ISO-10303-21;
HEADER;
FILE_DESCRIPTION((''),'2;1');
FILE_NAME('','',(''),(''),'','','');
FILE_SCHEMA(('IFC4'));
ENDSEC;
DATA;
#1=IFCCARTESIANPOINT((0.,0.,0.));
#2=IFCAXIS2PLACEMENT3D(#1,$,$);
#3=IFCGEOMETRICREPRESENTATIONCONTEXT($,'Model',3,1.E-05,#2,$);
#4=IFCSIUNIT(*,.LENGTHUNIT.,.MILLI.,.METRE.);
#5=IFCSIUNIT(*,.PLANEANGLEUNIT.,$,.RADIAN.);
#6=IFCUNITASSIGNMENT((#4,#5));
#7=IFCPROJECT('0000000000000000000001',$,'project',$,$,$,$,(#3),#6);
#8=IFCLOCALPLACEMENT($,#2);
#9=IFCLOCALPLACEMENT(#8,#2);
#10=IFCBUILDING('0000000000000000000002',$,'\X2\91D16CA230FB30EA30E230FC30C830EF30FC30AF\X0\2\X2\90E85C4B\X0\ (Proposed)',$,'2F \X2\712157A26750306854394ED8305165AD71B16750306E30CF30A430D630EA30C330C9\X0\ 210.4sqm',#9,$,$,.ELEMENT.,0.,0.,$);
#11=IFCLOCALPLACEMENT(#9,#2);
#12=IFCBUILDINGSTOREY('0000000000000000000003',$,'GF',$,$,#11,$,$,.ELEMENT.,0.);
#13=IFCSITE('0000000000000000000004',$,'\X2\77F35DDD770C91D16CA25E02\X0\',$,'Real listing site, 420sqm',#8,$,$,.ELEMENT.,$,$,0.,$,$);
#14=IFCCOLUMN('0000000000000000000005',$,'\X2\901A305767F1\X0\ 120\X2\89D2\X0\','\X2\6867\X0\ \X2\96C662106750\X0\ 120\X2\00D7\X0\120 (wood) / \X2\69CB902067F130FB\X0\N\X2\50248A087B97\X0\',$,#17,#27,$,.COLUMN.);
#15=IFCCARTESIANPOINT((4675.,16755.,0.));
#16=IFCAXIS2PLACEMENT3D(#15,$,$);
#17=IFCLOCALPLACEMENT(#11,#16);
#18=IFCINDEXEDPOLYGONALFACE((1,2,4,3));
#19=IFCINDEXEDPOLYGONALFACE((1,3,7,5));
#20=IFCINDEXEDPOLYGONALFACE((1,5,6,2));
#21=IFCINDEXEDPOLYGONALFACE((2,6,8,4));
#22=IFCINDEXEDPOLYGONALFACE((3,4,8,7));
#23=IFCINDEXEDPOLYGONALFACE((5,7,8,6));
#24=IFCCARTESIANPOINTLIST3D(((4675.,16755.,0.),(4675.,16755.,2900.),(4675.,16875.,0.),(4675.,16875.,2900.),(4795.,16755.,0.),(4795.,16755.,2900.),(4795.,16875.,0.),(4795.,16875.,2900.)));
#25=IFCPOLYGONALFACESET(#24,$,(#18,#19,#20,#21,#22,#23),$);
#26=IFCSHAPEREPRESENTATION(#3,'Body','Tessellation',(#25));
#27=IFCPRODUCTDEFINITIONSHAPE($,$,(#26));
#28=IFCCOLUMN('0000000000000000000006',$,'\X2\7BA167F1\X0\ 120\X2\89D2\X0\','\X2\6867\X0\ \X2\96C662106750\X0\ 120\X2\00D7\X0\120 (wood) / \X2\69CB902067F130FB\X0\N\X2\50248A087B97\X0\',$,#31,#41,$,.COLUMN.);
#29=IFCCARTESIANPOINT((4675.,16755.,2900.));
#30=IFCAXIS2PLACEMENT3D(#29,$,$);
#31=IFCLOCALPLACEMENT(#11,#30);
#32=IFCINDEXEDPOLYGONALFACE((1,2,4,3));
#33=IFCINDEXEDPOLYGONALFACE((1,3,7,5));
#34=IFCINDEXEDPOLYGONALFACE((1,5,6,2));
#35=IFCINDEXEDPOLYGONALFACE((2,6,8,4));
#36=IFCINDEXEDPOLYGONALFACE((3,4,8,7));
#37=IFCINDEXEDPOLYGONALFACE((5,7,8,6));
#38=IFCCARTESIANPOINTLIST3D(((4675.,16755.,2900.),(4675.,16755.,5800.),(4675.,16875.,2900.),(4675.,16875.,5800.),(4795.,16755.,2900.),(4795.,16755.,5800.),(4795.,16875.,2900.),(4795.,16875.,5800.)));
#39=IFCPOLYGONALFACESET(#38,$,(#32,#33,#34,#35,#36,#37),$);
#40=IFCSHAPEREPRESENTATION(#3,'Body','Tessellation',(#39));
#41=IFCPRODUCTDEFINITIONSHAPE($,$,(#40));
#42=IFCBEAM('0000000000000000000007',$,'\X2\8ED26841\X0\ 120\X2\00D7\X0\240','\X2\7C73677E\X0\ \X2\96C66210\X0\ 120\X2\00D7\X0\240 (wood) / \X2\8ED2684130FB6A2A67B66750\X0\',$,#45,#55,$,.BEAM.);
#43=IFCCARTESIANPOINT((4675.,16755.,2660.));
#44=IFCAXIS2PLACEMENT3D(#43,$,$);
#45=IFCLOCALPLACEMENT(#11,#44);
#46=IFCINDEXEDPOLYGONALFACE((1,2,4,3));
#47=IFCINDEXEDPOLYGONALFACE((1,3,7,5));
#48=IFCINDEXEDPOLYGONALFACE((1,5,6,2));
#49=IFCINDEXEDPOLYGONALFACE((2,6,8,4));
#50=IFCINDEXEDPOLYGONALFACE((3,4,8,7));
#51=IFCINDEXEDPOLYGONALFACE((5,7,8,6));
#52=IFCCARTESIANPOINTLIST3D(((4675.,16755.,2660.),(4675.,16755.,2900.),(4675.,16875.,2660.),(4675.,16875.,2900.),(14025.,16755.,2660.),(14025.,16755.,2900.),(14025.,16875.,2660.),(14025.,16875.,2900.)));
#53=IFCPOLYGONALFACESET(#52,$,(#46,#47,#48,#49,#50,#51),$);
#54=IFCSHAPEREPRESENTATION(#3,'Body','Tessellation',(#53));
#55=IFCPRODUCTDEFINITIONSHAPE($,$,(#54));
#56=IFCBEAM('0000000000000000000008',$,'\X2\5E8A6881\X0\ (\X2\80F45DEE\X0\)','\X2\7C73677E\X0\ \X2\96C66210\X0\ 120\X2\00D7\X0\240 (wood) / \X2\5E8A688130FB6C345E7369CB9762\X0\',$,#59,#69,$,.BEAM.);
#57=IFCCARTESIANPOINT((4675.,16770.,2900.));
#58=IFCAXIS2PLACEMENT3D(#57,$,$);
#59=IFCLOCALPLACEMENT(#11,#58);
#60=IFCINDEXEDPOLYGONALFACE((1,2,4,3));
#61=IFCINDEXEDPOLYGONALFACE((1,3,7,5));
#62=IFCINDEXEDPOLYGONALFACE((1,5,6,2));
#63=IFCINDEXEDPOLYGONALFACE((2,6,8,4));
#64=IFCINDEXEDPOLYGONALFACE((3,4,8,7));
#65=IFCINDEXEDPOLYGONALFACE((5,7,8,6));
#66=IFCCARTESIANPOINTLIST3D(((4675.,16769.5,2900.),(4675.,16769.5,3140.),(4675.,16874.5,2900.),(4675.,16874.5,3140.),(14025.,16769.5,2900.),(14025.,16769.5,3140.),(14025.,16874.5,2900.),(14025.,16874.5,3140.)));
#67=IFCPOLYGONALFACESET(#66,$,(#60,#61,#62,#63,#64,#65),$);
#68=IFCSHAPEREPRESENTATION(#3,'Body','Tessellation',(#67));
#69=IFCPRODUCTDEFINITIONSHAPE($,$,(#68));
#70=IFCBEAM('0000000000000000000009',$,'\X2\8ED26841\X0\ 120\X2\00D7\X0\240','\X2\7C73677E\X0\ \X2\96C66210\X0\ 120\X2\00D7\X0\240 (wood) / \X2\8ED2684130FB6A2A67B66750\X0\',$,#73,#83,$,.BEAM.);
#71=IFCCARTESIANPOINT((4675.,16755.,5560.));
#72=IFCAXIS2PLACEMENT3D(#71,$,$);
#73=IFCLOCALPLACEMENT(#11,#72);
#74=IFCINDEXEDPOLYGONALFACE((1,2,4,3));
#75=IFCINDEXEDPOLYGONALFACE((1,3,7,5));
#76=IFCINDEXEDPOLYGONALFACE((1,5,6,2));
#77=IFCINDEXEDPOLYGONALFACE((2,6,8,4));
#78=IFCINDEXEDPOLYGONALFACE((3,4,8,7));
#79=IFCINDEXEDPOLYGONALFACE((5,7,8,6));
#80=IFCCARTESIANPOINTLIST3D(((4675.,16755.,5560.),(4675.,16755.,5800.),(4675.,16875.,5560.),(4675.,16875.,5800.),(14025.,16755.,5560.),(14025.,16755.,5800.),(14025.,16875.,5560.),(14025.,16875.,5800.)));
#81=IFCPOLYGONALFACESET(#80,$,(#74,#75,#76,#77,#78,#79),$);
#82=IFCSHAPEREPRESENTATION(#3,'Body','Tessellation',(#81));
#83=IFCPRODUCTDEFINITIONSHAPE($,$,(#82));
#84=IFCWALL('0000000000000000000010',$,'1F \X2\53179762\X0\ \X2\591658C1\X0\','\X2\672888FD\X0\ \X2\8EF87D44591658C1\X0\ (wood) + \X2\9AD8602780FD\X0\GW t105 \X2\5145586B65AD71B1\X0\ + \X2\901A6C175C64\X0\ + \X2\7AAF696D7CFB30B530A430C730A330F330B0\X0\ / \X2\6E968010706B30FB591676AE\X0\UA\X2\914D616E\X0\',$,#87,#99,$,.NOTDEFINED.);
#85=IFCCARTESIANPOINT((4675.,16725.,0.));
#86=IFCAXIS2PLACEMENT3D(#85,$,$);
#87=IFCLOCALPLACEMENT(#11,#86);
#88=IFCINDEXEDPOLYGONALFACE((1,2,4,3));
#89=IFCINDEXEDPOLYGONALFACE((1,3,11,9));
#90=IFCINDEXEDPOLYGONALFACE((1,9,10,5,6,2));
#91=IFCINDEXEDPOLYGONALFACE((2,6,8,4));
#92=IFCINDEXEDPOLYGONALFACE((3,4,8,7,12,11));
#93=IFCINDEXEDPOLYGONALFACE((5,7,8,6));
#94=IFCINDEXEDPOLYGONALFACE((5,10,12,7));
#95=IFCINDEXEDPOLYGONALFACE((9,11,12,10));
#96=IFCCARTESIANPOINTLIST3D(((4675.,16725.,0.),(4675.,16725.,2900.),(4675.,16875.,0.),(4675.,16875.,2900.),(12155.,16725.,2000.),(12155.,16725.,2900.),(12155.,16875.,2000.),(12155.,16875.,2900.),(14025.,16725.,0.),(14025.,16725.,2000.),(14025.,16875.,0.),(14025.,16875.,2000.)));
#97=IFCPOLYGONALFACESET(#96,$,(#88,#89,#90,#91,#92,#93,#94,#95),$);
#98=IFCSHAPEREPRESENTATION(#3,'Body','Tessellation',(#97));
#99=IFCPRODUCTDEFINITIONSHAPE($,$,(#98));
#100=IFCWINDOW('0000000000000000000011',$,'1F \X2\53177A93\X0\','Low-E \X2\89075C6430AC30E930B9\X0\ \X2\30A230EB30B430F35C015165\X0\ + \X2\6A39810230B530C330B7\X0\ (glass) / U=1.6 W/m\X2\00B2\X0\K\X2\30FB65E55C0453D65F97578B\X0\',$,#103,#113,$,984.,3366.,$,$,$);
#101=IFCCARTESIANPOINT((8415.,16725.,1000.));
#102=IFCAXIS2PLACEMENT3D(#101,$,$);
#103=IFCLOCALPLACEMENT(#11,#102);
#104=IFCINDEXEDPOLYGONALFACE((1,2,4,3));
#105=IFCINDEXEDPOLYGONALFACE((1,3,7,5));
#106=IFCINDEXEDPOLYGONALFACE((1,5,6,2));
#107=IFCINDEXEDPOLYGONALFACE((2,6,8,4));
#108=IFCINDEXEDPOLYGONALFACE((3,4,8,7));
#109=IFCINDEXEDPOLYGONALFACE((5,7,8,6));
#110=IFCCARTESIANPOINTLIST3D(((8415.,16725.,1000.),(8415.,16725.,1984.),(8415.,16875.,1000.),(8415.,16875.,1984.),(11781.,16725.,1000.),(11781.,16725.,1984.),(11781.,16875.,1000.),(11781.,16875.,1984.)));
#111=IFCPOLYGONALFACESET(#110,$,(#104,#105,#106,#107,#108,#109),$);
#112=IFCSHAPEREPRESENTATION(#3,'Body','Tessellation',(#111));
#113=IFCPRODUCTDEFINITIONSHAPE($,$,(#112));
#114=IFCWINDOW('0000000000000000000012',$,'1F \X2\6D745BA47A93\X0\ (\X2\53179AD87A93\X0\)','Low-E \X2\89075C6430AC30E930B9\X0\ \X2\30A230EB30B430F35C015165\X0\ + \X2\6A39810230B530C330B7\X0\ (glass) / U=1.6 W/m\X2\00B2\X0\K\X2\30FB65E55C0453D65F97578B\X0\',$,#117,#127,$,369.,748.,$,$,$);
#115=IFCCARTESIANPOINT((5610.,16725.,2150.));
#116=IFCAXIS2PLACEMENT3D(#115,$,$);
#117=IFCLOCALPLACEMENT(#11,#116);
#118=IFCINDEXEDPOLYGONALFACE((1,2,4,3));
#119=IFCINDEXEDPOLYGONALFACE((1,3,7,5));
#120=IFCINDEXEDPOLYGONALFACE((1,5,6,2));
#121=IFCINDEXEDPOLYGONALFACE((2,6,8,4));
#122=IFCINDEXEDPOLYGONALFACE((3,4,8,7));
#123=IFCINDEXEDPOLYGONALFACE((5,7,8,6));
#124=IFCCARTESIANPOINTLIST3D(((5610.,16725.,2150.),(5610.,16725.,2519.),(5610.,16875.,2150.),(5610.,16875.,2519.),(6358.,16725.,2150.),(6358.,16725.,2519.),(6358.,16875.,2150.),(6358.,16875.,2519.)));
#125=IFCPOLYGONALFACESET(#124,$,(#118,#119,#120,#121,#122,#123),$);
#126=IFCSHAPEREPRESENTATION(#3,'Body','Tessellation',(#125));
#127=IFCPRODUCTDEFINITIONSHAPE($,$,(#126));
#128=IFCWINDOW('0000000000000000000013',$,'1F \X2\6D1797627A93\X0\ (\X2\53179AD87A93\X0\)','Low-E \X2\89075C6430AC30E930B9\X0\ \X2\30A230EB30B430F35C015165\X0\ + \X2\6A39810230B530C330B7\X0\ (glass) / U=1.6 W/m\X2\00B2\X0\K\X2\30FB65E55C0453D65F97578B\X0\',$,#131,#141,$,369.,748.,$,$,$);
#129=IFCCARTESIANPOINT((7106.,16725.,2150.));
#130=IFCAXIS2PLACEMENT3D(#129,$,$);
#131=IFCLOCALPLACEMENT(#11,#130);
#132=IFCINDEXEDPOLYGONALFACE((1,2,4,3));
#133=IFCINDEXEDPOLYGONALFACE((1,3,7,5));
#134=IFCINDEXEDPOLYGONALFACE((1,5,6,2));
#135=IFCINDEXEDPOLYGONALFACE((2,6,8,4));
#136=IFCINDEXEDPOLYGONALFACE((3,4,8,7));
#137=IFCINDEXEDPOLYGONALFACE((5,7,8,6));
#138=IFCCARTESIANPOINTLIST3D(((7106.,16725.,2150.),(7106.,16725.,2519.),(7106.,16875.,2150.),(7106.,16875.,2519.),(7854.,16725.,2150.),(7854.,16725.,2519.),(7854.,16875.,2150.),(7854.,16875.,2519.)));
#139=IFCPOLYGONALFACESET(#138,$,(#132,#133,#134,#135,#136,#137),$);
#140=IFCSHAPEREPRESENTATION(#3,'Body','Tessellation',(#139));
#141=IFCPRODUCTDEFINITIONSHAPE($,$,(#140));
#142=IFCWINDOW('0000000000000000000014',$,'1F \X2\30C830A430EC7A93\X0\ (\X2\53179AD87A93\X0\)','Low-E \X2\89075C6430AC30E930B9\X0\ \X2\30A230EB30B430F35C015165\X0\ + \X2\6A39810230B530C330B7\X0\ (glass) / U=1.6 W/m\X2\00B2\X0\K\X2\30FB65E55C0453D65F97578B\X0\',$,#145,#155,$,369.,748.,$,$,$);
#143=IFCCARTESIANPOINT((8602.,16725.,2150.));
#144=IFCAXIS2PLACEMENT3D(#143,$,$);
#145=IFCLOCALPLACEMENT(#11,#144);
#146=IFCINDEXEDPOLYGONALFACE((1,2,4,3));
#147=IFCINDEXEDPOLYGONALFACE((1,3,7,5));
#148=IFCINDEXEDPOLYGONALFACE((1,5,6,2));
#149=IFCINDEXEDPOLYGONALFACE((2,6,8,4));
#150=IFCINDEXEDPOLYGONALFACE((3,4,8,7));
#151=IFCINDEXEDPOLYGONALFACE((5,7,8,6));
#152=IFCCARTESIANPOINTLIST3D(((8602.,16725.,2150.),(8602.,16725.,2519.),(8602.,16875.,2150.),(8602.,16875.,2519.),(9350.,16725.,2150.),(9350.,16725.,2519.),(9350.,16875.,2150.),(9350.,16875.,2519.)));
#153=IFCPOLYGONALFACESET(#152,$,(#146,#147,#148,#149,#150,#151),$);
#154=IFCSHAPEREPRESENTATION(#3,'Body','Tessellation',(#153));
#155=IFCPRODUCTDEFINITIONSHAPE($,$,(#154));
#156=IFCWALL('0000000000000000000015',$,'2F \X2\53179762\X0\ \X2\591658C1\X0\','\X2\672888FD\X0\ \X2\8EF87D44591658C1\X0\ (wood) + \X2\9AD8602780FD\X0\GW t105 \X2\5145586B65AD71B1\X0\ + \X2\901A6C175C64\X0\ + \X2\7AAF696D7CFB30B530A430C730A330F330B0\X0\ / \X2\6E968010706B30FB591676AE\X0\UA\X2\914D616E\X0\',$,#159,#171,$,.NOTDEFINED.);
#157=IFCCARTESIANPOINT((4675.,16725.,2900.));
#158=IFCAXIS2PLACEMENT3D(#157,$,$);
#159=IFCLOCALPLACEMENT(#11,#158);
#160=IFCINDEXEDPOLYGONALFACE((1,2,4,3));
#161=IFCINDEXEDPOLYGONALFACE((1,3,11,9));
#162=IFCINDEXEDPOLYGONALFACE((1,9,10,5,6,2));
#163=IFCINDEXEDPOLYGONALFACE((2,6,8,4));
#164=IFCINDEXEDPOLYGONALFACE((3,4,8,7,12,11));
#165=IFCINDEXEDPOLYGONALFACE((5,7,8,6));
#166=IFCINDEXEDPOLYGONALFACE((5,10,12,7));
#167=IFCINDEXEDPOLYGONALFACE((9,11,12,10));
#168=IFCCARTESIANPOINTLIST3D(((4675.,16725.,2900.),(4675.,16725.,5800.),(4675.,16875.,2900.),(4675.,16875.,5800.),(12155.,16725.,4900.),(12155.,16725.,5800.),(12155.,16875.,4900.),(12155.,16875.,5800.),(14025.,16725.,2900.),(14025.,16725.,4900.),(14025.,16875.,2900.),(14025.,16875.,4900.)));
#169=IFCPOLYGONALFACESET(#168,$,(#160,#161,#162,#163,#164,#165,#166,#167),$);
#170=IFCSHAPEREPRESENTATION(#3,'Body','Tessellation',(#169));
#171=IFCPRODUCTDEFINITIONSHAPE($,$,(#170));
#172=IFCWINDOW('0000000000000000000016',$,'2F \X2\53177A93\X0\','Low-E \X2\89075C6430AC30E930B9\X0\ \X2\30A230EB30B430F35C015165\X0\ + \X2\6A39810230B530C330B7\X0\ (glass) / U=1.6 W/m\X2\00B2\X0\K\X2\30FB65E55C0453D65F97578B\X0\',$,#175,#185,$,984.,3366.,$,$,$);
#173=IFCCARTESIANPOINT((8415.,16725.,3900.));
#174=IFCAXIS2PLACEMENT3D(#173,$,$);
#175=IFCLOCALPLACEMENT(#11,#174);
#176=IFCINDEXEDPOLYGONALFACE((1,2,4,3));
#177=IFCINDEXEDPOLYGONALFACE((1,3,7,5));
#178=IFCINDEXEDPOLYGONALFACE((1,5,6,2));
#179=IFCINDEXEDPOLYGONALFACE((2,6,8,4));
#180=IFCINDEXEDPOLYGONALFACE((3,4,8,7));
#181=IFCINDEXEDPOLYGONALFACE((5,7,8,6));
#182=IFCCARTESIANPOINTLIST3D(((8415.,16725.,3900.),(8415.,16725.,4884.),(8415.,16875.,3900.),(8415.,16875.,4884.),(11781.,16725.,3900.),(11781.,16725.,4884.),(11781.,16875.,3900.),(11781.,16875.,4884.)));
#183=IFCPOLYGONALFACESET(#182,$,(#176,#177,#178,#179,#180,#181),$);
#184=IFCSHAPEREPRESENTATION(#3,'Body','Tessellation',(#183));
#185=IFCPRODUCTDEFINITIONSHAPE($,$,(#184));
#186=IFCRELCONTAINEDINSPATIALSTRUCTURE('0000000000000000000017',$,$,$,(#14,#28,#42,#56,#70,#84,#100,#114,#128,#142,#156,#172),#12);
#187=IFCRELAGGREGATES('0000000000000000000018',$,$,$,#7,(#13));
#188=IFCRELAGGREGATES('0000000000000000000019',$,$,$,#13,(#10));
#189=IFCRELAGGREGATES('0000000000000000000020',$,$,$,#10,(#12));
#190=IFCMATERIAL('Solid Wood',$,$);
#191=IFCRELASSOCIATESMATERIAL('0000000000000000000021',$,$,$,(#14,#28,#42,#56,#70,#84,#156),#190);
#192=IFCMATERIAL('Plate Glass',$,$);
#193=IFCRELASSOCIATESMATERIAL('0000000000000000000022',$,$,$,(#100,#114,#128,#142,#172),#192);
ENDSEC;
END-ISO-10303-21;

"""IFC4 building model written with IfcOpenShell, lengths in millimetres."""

from ifc_helpers import new_model, si_unit, frame, frame_2d, origin, place, context, project, spatial, rectangle, extrude, material, element, fill, save


model = new_model("IFC4")

# Units and contexts
model_context = context("Model", 3, precision=1e-05, world=origin())
ifc_project = project(units=[si_unit("LENGTHUNIT", "METRE", prefix="MILLI"), si_unit("PLANEANGLEUNIT", "RADIAN")], contexts=[model_context])

# Site, building, storey
site_placement = place(None, origin())
site = spatial("IfcSite", under=ifc_project, at=site_placement, Name="石川県金沢市", ObjectType="Real listing site, 420sqm", CompositionType="ELEMENT", RefElevation=0.0)
building_placement = place(site_placement, origin())
building = spatial("IfcBuilding", under=site, at=building_placement, Name="金沢・リモートワーク2部屋 (Proposed)", ObjectType="2F 無垢材と吹付け断熱材のハイブリッド 210.4sqm", CompositionType="ELEMENT", ElevationOfRefHeight=0.0, ElevationOfTerrain=0.0)
storey_placement = place(building_placement, origin())
storey = spatial("IfcBuildingStorey", under=building, at=storey_placement, Name="GF", CompositionType="ELEMENT", Elevation=0.0)

# Columns
ifc_material_1 = material(Name="Solid Wood")
column_1_placement = place(storey_placement, frame((4675.0, 16755.0, 0.0)))
element("IfcColumn", 1, at=column_1_placement, inside=storey, material=ifc_material_1, Name="通し柱 120角", Description="桧 集成材 120×120 (wood) / 構造柱・N値計算", PredefinedType="COLUMN", context=model_context, shape_type="SweptSolid", body=[
    extrude(rectangle(XDim=120.0, YDim=120.0, at=frame_2d((60.0, 60.0))), frame((4675.0, 16755.0, 0.0)), (0.0, 0.0, 1.0), 2900.0),
])
column_2_placement = place(storey_placement, frame((4675.0, 16755.0, 2900.0)))
element("IfcColumn", 2, at=column_2_placement, inside=storey, material=ifc_material_1, Name="管柱 120角", Description="桧 集成材 120×120 (wood) / 構造柱・N値計算", PredefinedType="COLUMN", context=model_context, shape_type="SweptSolid", body=[
    extrude(rectangle(XDim=120.0, YDim=120.0, at=frame_2d((60.0, 60.0))), frame((4675.0, 16755.0, 2900.0)), (0.0, 0.0, 1.0), 2900.0),
])

# Beams
beam_1_placement = place(storey_placement, frame((4675.0, 16755.0, 2660.0)))
element("IfcBeam", 3, at=beam_1_placement, inside=storey, material=ifc_material_1, Name="軒桁 120×240", Description="米松 集成 120×240 (wood) / 軒桁・横架材", PredefinedType="BEAM", context=model_context, shape_type="SweptSolid", body=[
    extrude(rectangle(XDim=9350.0, YDim=120.0, at=frame_2d((4675.0, 60.0))), frame((4675.0, 16755.0, 2660.0)), (0.0, 0.0, 1.0), 240.0),
])
beam_2_placement = place(storey_placement, frame((4675.0, 16770.0, 2900.0)))
element("IfcBeam", 4, at=beam_2_placement, inside=storey, material=ifc_material_1, Name="床梁 (胴差)", Description="米松 集成 120×240 (wood) / 床梁・水平構面", PredefinedType="BEAM", context=model_context, shape_type="SweptSolid", body=[
    extrude(rectangle(XDim=9350.0, YDim=105.0, at=frame_2d((4675.0, 52.0))), frame((4675.0, 16770.0, 2900.0)), (0.0, 0.0, 1.0), 240.0),
])
beam_3_placement = place(storey_placement, frame((4675.0, 16755.0, 5560.0)))
element("IfcBeam", 5, at=beam_3_placement, inside=storey, material=ifc_material_1, Name="軒桁 120×240", Description="米松 集成 120×240 (wood) / 軒桁・横架材", PredefinedType="BEAM", context=model_context, shape_type="SweptSolid", body=[
    extrude(rectangle(XDim=9350.0, YDim=120.0, at=frame_2d((4675.0, 60.0))), frame((4675.0, 16755.0, 5560.0)), (0.0, 0.0, 1.0), 240.0),
])

# Wall, openings, windows
wall_1_placement = place(storey_placement, frame((4675.0, 16725.0, 0.0)))
wall_1 = element("IfcWall", 6, at=wall_1_placement, inside=storey, material=ifc_material_1, Name="1F 北面 外壁", Description="木製 軸組外壁 (wood) + 高性能GW t105 充填断熱 + 通気層 + 窯業系サイディング / 準耐火・外皮UA配慮", PredefinedType="NOTDEFINED", context=model_context, shape_type="SweptSolid", body=[
    extrude(rectangle(XDim=9350.0, YDim=150.0, at=frame_2d((4675.0, 75.0))), frame((4675.0, 16725.0, 0.0)), (0.0, 0.0, 1.0), 2900.0),
])
opening_1_placement = place(storey_placement, frame((8415.0, 16725.0, 1000.0)))
opening_1 = element("IfcOpeningElement", 7, at=opening_1_placement, cuts=wall_1, PredefinedType="NOTDEFINED", context=model_context, shape_type="SweptSolid", body=[
    extrude(rectangle(XDim=3366.0, YDim=150.0, at=frame_2d((1683.0, 75.0))), frame((8415.0, 16725.0, 1000.0)), (0.0, 0.0, 1.0), 984.0),
])
opening_2_placement = place(storey_placement, frame((5610.0, 16725.0, 2150.0)))
opening_2 = element("IfcOpeningElement", 8, at=opening_2_placement, cuts=wall_1, PredefinedType="NOTDEFINED", context=model_context, shape_type="SweptSolid", body=[
    extrude(rectangle(XDim=748.0, YDim=150.0, at=frame_2d((374.0, 75.0))), frame((5610.0, 16725.0, 2150.0)), (0.0, 0.0, 1.0), 369.0),
])
opening_3_placement = place(storey_placement, frame((7106.0, 16725.0, 2150.0)))
opening_3 = element("IfcOpeningElement", 9, at=opening_3_placement, cuts=wall_1, PredefinedType="NOTDEFINED", context=model_context, shape_type="SweptSolid", body=[
    extrude(rectangle(XDim=748.0, YDim=150.0, at=frame_2d((374.0, 75.0))), frame((7106.0, 16725.0, 2150.0)), (0.0, 0.0, 1.0), 369.0),
])
opening_4_placement = place(storey_placement, frame((8602.0, 16725.0, 2150.0)))
opening_4 = element("IfcOpeningElement", 10, at=opening_4_placement, cuts=wall_1, PredefinedType="NOTDEFINED", context=model_context, shape_type="SweptSolid", body=[
    extrude(rectangle(XDim=748.0, YDim=150.0, at=frame_2d((374.0, 75.0))), frame((8602.0, 16725.0, 2150.0)), (0.0, 0.0, 1.0), 369.0),
])
ifc_material_2 = material(Name="Plate Glass")
window_1_placement = place(storey_placement, frame((8415.0, 16725.0, 1000.0)))
window_1 = element("IfcWindow", 11, at=window_1_placement, inside=storey, material=ifc_material_2, Name="1F 北窓", Description="Low-E 複層ガラス アルゴン封入 + 樹脂サッシ (glass) / U=1.6 W/m²K・日射取得型", OverallHeight=984.0, OverallWidth=3366.0, context=model_context, shape_type="SweptSolid", body=[
    extrude(rectangle(XDim=3366.0, YDim=150.0, at=frame_2d((1683.0, 75.0))), frame((8415.0, 16725.0, 1000.0)), (0.0, 0.0, 1.0), 984.0),
])
fill(opening_1, window_1)
window_2_placement = place(storey_placement, frame((5610.0, 16725.0, 2150.0)))
window_2 = element("IfcWindow", 12, at=window_2_placement, inside=storey, material=ifc_material_2, Name="1F 浴室窓 (北高窓)", Description="Low-E 複層ガラス アルゴン封入 + 樹脂サッシ (glass) / U=1.6 W/m²K・日射取得型", OverallHeight=369.0, OverallWidth=748.0, context=model_context, shape_type="SweptSolid", body=[
    extrude(rectangle(XDim=748.0, YDim=150.0, at=frame_2d((374.0, 75.0))), frame((5610.0, 16725.0, 2150.0)), (0.0, 0.0, 1.0), 369.0),
])
fill(opening_2, window_2)
window_3_placement = place(storey_placement, frame((7106.0, 16725.0, 2150.0)))
window_3 = element("IfcWindow", 13, at=window_3_placement, inside=storey, material=ifc_material_2, Name="1F 洗面窓 (北高窓)", Description="Low-E 複層ガラス アルゴン封入 + 樹脂サッシ (glass) / U=1.6 W/m²K・日射取得型", OverallHeight=369.0, OverallWidth=748.0, context=model_context, shape_type="SweptSolid", body=[
    extrude(rectangle(XDim=748.0, YDim=150.0, at=frame_2d((374.0, 75.0))), frame((7106.0, 16725.0, 2150.0)), (0.0, 0.0, 1.0), 369.0),
])
fill(opening_3, window_3)
window_4_placement = place(storey_placement, frame((8602.0, 16725.0, 2150.0)))
window_4 = element("IfcWindow", 14, at=window_4_placement, inside=storey, material=ifc_material_2, Name="1F トイレ窓 (北高窓)", Description="Low-E 複層ガラス アルゴン封入 + 樹脂サッシ (glass) / U=1.6 W/m²K・日射取得型", OverallHeight=369.0, OverallWidth=748.0, context=model_context, shape_type="SweptSolid", body=[
    extrude(rectangle(XDim=748.0, YDim=150.0, at=frame_2d((374.0, 75.0))), frame((8602.0, 16725.0, 2150.0)), (0.0, 0.0, 1.0), 369.0),
])
fill(opening_4, window_4)

# Wall, opening, window
wall_2_placement = place(storey_placement, frame((4675.0, 16725.0, 2900.0)))
wall_2 = element("IfcWall", 15, at=wall_2_placement, inside=storey, material=ifc_material_1, Name="2F 北面 外壁", Description="木製 軸組外壁 (wood) + 高性能GW t105 充填断熱 + 通気層 + 窯業系サイディング / 準耐火・外皮UA配慮", PredefinedType="NOTDEFINED", context=model_context, shape_type="SweptSolid", body=[
    extrude(rectangle(XDim=9350.0, YDim=150.0, at=frame_2d((4675.0, 75.0))), frame((4675.0, 16725.0, 2900.0)), (0.0, 0.0, 1.0), 2900.0),
])
opening_5_placement = place(storey_placement, frame((8415.0, 16725.0, 3900.0)))
opening_5 = element("IfcOpeningElement", 16, at=opening_5_placement, cuts=wall_2, PredefinedType="NOTDEFINED", context=model_context, shape_type="SweptSolid", body=[
    extrude(rectangle(XDim=3366.0, YDim=150.0, at=frame_2d((1683.0, 75.0))), frame((8415.0, 16725.0, 3900.0)), (0.0, 0.0, 1.0), 984.0),
])
window_5_placement = place(storey_placement, frame((8415.0, 16725.0, 3900.0)))
window_5 = element("IfcWindow", 17, at=window_5_placement, inside=storey, material=ifc_material_2, Name="2F 北窓", Description="Low-E 複層ガラス アルゴン封入 + 樹脂サッシ (glass) / U=1.6 W/m²K・日射取得型", OverallHeight=984.0, OverallWidth=3366.0, context=model_context, shape_type="SweptSolid", body=[
    extrude(rectangle(XDim=3366.0, YDim=150.0, at=frame_2d((1683.0, 75.0))), frame((8415.0, 16725.0, 3900.0)), (0.0, 0.0, 1.0), 984.0),
])
fill(opening_5, window_5)

save(model, "model.ifc")
